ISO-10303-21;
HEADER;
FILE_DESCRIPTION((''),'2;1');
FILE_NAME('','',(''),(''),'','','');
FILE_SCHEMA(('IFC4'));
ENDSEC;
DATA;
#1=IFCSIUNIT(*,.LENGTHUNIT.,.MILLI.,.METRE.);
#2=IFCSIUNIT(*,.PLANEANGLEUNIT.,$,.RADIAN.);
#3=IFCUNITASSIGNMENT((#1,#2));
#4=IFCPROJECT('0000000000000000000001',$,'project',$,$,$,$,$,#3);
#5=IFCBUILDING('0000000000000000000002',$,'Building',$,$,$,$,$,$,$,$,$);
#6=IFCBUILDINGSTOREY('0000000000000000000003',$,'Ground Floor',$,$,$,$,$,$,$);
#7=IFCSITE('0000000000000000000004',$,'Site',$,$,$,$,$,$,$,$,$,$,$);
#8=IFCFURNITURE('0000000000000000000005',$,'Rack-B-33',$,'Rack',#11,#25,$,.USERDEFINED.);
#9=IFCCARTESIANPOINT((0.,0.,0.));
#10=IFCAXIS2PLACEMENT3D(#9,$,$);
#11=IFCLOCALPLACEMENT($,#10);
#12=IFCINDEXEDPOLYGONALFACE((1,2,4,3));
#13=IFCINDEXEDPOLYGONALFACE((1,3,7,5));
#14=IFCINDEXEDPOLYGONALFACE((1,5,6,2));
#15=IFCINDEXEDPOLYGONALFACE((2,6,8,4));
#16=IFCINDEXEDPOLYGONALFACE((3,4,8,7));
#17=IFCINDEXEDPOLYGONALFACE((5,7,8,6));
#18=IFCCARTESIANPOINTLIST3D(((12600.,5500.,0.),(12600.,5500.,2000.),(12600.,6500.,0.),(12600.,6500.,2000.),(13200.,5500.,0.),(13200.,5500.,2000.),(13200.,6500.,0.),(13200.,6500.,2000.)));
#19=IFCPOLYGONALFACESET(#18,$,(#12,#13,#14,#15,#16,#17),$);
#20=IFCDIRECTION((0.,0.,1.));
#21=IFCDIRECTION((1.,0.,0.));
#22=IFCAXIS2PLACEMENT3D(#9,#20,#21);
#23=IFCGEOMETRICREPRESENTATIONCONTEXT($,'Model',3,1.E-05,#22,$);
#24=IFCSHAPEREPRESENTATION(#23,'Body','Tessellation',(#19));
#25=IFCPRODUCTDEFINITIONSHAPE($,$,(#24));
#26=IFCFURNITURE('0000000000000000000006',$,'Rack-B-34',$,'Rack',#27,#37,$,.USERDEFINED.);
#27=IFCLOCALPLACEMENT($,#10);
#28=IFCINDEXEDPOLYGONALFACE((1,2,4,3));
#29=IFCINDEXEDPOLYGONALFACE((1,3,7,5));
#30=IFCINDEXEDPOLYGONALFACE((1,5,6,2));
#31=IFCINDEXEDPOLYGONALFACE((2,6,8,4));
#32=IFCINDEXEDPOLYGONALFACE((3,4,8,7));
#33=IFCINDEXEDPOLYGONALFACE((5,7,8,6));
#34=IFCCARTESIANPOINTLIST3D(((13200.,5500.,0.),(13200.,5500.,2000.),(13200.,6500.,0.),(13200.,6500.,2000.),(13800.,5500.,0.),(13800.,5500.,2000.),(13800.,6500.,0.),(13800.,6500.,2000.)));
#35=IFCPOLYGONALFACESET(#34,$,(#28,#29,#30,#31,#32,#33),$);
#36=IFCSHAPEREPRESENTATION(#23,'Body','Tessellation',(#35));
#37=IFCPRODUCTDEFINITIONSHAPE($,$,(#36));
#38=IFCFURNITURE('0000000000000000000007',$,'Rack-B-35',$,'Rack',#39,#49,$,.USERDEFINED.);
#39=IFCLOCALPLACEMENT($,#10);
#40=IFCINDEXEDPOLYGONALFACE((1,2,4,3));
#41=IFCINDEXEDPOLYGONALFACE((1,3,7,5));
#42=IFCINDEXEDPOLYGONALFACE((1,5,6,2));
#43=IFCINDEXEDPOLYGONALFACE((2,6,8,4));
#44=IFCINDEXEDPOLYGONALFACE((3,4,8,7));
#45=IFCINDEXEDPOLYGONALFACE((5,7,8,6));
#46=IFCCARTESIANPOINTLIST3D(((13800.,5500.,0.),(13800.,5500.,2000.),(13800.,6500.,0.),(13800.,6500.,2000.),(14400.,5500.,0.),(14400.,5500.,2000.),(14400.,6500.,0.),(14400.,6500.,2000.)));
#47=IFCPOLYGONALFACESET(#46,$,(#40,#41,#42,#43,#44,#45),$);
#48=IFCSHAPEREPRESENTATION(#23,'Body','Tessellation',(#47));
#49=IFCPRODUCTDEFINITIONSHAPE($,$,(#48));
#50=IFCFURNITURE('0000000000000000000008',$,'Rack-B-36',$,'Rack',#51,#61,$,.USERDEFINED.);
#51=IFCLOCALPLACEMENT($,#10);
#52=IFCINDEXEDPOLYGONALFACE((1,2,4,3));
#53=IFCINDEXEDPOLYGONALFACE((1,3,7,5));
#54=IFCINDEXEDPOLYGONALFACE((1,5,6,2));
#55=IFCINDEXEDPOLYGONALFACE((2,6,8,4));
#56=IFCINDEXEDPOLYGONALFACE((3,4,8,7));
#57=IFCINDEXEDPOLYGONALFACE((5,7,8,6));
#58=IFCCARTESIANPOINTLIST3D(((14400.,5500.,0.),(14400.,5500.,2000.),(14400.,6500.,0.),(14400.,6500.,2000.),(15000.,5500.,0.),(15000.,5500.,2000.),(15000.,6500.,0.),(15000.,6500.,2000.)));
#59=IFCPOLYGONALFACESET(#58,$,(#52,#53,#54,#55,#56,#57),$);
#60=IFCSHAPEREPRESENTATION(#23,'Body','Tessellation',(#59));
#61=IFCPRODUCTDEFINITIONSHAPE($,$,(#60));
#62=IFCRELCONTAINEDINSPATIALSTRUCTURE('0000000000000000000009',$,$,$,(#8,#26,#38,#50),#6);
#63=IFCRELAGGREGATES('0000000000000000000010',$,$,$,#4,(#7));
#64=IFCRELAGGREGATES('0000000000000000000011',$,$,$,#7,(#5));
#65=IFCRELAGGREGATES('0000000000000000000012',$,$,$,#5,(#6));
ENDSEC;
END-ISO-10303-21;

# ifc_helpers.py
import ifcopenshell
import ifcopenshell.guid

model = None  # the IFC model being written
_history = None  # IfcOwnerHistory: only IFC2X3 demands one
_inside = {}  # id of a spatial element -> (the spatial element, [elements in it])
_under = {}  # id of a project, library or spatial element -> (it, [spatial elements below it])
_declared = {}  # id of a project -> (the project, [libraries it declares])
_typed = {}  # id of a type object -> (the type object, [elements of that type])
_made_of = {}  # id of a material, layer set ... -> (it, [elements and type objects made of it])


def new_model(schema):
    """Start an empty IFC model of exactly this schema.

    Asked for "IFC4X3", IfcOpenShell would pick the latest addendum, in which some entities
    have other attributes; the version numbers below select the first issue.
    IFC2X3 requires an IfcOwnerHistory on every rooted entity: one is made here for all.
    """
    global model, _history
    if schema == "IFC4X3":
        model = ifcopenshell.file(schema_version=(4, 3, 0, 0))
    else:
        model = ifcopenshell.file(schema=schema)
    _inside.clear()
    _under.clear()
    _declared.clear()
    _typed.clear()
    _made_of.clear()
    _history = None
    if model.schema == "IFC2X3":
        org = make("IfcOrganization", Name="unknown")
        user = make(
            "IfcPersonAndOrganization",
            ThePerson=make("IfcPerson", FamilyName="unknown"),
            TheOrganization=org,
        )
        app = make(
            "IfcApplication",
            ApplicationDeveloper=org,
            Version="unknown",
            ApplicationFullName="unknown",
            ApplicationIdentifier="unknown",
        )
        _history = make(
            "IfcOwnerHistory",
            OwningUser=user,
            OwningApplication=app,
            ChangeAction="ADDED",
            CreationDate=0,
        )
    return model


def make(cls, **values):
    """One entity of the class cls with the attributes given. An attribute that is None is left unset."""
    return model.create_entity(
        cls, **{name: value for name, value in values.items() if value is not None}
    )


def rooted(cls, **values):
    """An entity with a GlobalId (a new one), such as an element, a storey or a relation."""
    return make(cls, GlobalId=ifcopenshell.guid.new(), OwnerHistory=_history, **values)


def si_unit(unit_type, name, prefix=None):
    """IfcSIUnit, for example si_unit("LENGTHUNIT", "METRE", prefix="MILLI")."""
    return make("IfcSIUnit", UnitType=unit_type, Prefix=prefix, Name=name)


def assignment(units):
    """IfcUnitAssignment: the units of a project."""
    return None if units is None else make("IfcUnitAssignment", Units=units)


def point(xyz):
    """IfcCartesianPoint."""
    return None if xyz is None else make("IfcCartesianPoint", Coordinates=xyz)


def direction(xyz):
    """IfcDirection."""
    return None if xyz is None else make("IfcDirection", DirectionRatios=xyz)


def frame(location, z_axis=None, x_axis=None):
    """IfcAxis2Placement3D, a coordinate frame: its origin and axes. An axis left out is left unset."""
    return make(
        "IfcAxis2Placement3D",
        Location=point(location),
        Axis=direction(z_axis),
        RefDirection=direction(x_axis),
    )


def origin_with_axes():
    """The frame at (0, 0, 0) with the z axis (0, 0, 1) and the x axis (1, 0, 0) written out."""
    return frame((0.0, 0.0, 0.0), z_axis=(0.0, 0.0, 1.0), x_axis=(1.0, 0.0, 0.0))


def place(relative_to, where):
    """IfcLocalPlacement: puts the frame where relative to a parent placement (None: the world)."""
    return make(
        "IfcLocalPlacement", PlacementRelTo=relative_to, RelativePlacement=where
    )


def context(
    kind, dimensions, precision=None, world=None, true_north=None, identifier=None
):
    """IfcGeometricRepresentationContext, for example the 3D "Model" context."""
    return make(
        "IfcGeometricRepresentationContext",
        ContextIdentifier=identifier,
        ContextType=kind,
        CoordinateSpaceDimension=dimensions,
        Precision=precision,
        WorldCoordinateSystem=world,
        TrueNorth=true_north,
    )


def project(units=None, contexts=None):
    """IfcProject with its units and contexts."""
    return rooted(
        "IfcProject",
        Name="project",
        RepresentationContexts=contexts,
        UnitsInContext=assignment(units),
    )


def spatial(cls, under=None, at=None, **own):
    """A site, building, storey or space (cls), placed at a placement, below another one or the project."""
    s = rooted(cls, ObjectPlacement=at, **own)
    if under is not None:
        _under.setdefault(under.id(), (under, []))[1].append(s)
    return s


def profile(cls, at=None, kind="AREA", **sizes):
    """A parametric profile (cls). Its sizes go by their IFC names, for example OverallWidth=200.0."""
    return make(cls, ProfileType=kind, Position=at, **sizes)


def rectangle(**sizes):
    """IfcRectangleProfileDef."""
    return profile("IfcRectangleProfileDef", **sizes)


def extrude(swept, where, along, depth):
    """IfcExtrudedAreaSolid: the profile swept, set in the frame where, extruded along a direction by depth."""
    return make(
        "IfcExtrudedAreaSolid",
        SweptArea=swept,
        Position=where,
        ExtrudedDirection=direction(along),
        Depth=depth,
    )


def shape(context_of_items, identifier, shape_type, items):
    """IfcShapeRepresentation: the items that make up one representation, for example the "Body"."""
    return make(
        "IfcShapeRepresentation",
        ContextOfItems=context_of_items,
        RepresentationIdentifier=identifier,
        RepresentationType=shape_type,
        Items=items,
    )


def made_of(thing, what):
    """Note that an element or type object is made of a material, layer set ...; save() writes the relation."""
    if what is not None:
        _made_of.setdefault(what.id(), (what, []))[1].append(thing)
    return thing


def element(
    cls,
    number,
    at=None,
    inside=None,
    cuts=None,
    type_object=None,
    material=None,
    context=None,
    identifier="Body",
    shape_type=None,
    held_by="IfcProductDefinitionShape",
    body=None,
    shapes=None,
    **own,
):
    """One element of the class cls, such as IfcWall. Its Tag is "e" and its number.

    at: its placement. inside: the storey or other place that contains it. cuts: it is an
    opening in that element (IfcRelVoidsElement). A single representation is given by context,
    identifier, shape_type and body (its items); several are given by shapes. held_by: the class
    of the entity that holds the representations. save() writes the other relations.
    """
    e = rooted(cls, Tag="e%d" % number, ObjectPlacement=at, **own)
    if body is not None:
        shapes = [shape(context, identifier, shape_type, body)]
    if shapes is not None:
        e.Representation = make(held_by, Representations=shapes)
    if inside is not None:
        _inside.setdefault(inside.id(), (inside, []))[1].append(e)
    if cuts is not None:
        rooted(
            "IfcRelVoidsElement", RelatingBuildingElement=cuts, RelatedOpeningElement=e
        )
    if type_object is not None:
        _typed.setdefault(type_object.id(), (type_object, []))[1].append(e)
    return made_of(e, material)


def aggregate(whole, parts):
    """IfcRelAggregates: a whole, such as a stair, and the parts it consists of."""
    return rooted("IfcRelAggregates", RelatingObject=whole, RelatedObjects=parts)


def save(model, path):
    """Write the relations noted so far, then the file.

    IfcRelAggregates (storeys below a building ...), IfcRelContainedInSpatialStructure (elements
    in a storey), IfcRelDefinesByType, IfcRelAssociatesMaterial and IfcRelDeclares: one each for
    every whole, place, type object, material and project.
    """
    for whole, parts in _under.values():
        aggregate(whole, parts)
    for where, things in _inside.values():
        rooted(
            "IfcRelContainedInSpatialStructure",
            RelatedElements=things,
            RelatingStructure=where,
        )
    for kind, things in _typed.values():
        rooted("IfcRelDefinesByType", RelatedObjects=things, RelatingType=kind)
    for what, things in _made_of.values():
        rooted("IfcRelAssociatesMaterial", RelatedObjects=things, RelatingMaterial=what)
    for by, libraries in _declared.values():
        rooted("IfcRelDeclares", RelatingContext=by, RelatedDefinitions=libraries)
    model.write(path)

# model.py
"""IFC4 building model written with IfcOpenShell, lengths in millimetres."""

from ifc_helpers import new_model, si_unit, frame, origin_with_axes, place, context, project, spatial, rectangle, extrude, element, save


model = new_model("IFC4")

# Units and contexts
model_context = context("Model", 3, precision=1e-05, world=origin_with_axes())
ifc_project = project(units=[si_unit("LENGTHUNIT", "METRE", prefix="MILLI"), si_unit("PLANEANGLEUNIT", "RADIAN")])

# Site, building, storey
site = spatial("IfcSite", under=ifc_project, Name="Site")
building = spatial("IfcBuilding", under=site, Name="Building")
storey = spatial("IfcBuildingStorey", under=building, Name="Ground Floor")

# Furniture
furniture_1_placement = place(None, origin_with_axes())
element("IfcFurniture", 1, at=furniture_1_placement, inside=storey, Name="Rack-B-33", ObjectType="Rack", PredefinedType="USERDEFINED", context=model_context, shape_type="SweptSolid", body=[
    extrude(rectangle(XDim=600.0, YDim=1000.0), frame((12900.0, 6000.0, 0.0), z_axis=(0.0, 0.0, 1.0), x_axis=(1.0, 0.0, 0.0)), (0.0, 0.0, 1.0), 2000.0),
])
furniture_2_placement = place(None, origin_with_axes())
element("IfcFurniture", 2, at=furniture_2_placement, inside=storey, Name="Rack-B-34", ObjectType="Rack", PredefinedType="USERDEFINED", context=model_context, shape_type="SweptSolid", body=[
    extrude(rectangle(XDim=600.0, YDim=1000.0), frame((13500.0, 6000.0, 0.0), z_axis=(0.0, 0.0, 1.0), x_axis=(1.0, 0.0, 0.0)), (0.0, 0.0, 1.0), 2000.0),
])
furniture_3_placement = place(None, origin_with_axes())
element("IfcFurniture", 3, at=furniture_3_placement, inside=storey, Name="Rack-B-35", ObjectType="Rack", PredefinedType="USERDEFINED", context=model_context, shape_type="SweptSolid", body=[
    extrude(rectangle(XDim=600.0, YDim=1000.0), frame((14100.0, 6000.0, 0.0), z_axis=(0.0, 0.0, 1.0), x_axis=(1.0, 0.0, 0.0)), (0.0, 0.0, 1.0), 2000.0),
])
furniture_4_placement = place(None, origin_with_axes())
element("IfcFurniture", 4, at=furniture_4_placement, inside=storey, Name="Rack-B-36", ObjectType="Rack", PredefinedType="USERDEFINED", context=model_context, shape_type="SweptSolid", body=[
    extrude(rectangle(XDim=600.0, YDim=1000.0), frame((14700.0, 6000.0, 0.0), z_axis=(0.0, 0.0, 1.0), x_axis=(1.0, 0.0, 0.0)), (0.0, 0.0, 1.0), 2000.0),
])

save(model, "model.ifc")
